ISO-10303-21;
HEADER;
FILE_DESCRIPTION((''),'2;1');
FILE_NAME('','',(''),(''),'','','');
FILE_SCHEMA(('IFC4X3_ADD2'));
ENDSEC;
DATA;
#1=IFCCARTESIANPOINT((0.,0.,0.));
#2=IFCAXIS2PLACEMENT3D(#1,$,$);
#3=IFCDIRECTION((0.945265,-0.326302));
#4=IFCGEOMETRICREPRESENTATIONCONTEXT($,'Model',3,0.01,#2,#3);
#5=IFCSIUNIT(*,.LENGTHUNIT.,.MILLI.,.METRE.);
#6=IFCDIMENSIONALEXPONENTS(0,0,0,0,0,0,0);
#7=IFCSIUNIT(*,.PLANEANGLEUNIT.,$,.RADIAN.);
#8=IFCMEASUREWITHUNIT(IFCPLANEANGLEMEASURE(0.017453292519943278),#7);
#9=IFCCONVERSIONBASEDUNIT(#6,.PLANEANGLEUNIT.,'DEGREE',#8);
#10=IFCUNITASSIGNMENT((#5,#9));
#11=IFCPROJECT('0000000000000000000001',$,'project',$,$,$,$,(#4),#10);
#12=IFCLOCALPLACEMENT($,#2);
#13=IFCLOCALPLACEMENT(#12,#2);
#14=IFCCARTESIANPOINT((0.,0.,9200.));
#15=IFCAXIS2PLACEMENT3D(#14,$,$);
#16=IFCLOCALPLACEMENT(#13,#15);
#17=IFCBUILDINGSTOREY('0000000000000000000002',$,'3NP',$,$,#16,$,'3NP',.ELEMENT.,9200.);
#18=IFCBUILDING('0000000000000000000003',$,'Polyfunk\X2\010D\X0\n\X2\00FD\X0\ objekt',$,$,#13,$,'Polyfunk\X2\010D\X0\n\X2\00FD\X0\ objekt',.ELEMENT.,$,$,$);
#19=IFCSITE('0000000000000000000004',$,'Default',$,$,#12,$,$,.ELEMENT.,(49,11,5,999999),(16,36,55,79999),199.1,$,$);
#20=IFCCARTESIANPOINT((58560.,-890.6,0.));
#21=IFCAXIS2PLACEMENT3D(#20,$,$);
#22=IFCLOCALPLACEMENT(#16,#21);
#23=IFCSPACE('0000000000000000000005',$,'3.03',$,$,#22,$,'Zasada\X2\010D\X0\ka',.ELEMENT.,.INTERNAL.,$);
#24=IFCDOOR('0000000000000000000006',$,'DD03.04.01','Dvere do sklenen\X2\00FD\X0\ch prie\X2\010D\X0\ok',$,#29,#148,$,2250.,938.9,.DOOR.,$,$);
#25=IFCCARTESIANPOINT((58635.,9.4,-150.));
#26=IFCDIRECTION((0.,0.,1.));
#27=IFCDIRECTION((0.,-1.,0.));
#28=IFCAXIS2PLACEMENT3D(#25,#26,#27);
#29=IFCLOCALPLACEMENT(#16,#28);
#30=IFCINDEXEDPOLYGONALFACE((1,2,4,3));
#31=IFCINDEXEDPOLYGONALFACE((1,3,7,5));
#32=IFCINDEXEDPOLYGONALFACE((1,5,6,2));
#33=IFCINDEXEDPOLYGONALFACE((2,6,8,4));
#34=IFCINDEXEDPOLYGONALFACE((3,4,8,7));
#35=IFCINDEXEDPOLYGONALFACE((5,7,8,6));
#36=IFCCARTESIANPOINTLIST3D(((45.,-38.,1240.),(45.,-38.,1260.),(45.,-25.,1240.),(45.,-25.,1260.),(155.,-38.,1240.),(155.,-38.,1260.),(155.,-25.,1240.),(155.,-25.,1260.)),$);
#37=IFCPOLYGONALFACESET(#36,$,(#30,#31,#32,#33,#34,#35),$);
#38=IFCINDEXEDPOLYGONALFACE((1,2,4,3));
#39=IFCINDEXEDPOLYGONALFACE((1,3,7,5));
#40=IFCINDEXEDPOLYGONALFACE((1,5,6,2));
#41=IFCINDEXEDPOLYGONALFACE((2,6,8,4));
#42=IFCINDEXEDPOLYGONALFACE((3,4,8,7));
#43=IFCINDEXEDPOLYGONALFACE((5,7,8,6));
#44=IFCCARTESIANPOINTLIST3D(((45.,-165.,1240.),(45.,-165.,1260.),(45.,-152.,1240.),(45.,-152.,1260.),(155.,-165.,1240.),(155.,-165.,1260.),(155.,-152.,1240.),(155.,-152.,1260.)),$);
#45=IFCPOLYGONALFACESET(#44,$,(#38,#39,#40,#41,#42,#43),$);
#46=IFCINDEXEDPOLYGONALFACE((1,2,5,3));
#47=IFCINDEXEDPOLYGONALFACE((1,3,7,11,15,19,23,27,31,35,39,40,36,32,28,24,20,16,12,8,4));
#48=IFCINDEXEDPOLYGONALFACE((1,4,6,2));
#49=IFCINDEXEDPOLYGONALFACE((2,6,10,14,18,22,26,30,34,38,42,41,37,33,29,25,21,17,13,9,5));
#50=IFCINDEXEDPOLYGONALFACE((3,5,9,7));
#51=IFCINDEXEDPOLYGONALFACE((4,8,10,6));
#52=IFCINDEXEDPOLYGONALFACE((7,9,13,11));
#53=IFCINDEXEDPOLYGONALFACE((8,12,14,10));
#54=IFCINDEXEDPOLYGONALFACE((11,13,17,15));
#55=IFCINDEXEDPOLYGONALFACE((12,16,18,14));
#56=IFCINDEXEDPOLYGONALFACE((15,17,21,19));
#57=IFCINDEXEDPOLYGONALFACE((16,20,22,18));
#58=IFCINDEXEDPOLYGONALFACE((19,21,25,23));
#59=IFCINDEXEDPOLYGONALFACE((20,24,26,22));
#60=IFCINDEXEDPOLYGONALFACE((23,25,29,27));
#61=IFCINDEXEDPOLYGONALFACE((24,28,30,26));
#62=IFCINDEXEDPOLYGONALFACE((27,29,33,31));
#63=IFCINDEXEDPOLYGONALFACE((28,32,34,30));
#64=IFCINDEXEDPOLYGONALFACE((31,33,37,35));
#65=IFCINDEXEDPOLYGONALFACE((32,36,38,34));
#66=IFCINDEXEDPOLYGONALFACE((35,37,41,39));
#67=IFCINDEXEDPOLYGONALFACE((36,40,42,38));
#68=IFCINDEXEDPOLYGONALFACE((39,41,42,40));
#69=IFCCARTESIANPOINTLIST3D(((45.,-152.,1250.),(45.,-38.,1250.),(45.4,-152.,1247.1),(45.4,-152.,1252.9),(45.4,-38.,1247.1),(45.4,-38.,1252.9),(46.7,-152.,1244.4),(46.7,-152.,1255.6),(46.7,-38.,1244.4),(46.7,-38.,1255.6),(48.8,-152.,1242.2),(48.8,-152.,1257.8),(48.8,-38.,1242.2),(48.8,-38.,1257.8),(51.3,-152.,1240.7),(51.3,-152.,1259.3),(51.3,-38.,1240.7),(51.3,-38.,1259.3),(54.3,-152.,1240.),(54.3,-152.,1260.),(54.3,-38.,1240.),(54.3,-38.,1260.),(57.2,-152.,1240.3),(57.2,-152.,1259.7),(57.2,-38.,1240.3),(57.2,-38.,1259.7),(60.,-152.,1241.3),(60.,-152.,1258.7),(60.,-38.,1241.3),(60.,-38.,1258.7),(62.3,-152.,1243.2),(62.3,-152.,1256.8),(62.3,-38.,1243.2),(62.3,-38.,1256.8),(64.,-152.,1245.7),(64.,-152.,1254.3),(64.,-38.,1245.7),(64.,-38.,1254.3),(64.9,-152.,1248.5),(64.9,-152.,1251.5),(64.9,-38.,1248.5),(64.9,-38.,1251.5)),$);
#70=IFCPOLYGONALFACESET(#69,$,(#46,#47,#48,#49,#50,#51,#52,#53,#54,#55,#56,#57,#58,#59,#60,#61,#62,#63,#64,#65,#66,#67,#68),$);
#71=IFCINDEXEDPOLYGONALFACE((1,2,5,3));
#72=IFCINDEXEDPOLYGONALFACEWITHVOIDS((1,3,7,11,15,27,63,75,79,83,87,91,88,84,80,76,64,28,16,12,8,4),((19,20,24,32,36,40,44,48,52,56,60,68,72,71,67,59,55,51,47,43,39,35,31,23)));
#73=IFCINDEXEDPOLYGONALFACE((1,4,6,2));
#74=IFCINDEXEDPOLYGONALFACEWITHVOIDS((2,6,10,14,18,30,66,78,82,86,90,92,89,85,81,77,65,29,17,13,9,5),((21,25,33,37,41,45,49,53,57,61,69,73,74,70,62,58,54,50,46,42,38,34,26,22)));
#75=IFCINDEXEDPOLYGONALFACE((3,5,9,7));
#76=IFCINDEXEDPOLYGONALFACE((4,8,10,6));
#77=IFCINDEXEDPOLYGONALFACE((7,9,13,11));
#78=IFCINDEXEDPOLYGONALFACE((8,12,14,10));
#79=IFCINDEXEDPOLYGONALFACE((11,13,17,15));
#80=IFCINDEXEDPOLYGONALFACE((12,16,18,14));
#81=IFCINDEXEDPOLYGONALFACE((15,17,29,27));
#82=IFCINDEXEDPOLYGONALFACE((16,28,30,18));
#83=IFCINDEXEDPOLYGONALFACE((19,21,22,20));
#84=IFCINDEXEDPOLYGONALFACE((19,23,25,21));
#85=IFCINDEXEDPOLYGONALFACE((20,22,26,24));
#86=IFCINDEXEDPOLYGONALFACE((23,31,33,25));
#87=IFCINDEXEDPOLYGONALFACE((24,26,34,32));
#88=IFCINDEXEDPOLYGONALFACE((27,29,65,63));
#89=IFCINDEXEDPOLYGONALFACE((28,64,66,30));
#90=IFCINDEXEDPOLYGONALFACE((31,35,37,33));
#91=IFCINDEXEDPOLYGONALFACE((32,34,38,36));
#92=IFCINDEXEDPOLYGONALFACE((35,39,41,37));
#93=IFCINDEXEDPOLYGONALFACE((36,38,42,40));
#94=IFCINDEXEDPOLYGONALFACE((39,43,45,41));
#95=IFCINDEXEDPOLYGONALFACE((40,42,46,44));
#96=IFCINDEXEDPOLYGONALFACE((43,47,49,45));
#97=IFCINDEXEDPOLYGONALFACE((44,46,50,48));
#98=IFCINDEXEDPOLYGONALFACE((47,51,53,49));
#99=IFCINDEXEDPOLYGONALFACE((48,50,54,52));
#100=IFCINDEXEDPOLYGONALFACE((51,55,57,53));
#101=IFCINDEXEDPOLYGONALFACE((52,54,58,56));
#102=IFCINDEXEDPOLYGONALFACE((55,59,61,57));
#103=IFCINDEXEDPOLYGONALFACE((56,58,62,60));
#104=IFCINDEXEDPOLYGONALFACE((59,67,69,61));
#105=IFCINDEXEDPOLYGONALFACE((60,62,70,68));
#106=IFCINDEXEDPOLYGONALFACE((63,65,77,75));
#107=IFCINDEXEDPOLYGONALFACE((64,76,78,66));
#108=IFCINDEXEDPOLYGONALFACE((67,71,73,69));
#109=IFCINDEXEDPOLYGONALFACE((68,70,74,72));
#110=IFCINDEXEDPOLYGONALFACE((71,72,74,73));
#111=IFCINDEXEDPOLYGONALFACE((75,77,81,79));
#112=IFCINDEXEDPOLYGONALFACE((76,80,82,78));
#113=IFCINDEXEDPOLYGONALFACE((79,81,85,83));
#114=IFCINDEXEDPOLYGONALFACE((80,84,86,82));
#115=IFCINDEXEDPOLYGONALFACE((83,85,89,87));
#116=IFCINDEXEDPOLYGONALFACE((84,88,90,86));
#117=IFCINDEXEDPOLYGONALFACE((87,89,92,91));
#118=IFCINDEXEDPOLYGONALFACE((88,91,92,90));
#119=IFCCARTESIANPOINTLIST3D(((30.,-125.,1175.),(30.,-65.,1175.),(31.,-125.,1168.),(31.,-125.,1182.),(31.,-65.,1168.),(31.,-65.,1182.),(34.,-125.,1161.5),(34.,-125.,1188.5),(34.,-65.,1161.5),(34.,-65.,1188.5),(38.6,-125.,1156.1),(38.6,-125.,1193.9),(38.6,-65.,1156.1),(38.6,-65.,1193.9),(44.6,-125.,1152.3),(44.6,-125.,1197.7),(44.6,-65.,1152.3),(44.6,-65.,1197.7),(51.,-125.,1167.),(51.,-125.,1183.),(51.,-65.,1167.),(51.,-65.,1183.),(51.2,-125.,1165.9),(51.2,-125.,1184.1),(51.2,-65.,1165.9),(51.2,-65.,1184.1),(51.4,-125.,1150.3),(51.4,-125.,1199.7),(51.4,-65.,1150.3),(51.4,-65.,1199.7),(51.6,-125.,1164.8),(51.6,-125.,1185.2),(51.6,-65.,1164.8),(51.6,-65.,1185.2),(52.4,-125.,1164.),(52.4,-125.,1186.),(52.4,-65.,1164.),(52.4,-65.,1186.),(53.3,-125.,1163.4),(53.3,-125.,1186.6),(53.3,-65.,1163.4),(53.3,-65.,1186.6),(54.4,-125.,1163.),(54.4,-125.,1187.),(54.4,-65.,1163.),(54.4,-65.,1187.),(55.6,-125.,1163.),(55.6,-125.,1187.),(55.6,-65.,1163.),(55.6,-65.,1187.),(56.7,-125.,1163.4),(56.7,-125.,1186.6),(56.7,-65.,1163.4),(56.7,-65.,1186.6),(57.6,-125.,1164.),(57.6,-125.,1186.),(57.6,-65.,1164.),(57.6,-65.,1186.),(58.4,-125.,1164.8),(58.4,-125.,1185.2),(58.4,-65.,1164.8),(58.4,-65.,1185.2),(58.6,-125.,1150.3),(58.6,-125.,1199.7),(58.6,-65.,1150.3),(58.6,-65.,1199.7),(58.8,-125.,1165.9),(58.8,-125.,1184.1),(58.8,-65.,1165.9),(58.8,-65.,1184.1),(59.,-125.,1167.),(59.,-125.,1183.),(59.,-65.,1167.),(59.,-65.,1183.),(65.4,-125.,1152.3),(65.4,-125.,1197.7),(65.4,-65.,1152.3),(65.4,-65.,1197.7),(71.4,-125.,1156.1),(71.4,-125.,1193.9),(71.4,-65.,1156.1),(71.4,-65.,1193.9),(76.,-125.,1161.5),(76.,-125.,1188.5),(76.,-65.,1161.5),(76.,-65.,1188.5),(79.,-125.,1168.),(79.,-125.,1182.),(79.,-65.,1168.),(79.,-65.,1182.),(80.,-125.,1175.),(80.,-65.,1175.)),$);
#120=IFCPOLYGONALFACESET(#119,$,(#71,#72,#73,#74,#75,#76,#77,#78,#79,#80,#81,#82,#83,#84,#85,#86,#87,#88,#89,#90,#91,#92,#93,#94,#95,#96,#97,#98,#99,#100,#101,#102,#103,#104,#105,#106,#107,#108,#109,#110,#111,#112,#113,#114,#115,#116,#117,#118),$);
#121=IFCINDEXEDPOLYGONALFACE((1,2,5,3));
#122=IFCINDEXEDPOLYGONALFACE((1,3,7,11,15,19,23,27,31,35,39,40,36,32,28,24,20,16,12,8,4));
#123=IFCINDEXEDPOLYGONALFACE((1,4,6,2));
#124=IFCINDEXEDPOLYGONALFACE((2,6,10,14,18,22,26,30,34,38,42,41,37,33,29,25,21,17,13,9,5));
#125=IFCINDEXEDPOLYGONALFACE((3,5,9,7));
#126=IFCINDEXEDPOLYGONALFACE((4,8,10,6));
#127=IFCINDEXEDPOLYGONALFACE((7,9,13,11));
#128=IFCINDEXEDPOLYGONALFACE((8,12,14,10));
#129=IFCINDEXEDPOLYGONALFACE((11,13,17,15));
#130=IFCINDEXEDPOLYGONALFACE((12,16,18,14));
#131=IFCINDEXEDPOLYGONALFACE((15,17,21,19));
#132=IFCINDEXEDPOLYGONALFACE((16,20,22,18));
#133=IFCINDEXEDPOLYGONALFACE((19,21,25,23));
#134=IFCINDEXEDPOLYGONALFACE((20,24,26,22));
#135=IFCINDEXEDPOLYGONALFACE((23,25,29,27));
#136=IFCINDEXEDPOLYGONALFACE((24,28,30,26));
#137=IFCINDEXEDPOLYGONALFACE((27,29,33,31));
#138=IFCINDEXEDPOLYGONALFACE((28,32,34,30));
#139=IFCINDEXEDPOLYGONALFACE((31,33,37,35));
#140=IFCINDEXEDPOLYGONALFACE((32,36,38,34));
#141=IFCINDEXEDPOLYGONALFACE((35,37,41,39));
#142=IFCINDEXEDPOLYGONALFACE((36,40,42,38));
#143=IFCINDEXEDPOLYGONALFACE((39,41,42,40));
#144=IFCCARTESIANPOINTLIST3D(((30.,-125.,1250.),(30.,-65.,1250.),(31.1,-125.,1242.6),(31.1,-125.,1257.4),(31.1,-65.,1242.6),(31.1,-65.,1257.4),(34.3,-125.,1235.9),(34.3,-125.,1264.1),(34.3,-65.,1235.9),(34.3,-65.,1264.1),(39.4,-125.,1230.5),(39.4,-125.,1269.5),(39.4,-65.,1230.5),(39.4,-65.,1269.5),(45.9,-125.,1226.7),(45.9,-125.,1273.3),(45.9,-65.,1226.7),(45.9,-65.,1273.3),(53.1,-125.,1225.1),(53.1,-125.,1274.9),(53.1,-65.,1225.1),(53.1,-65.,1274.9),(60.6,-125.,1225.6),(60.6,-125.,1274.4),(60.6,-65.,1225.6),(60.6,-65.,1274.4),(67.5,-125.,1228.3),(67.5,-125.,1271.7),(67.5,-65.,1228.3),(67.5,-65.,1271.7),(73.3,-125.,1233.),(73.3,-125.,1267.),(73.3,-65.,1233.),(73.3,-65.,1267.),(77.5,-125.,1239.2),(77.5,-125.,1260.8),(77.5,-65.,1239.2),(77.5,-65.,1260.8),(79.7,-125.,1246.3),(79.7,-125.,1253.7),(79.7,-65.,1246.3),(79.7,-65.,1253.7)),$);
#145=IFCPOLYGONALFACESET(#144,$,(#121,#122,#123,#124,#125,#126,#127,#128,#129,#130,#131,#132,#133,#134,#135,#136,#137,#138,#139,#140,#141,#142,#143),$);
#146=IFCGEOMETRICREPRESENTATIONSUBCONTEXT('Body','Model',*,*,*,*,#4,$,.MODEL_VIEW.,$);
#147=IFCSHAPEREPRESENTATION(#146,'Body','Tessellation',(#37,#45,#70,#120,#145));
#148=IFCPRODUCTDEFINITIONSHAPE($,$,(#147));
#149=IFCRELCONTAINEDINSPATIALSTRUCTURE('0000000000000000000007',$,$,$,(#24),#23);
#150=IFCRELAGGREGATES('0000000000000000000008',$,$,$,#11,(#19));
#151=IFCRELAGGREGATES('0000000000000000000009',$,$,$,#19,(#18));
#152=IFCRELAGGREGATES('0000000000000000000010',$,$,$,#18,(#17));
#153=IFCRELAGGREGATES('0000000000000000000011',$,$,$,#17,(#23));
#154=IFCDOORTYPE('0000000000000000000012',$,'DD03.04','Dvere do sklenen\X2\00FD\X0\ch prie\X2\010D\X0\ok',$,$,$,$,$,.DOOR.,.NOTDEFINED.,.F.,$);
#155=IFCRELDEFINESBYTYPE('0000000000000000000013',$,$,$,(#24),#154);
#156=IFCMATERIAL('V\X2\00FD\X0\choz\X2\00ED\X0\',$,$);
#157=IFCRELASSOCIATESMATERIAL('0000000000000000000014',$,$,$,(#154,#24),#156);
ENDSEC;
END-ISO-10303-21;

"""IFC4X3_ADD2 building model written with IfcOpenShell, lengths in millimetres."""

from ifc_helpers import new_model, entity, si_unit, converted_unit, direction, frame, frame_2d, origin, origin_2d_with_axis, place, context, subcontext, project, spatial, polyline, circle_curve, parameter, trimmed, segment, composite_curve, rectangle, circle, outline, extrude, source, transform, mapped, material, type_object, type_shapes, element, save


model = new_model("IFC4X3_ADD2")

# Units and contexts
model_context = context("Model", 3, precision=0.01, world=origin(), true_north=direction((0.945265, -0.326302)))
body_context = subcontext(model_context, "Body", "Model", "MODEL_VIEW")
ifc_project = project(units=[si_unit("LENGTHUNIT", "METRE", prefix="MILLI"), converted_unit("PLANEANGLEUNIT", "DEGREE", entity("IfcPlaneAngleMeasure", 0.017453292519943278), si_unit("PLANEANGLEUNIT", "RADIAN"), dimensions=[0, 0, 0, 0, 0, 0, 0])], contexts=[model_context])

# Site, building, storey
site_placement = place(None, origin())
site = spatial("IfcSite", under=ifc_project, at=site_placement, Name="Default", CompositionType="ELEMENT", RefLatitude=(49, 11, 5, 999999), RefLongitude=(16, 36, 55, 79999), RefElevation=199.1)
building_placement = place(site_placement, origin())
building = spatial("IfcBuilding", under=site, at=building_placement, Name="Polyfunkčný objekt", LongName="Polyfunkčný objekt", CompositionType="ELEMENT")
storey_placement = place(building_placement, frame((0.0, 0.0, 9200.0)))
storey = spatial("IfcBuildingStorey", under=building, at=storey_placement, Name="3NP", LongName="3NP", CompositionType="ELEMENT", Elevation=9200.0)

# Shared definitions
space_placement = place(storey_placement, frame((58560.0, -890.6, 0.0)))
space = spatial("IfcSpace", under=storey, at=space_placement, Name="3.03", LongName="Zasadačka", CompositionType="ELEMENT", PredefinedType="INTERNAL")

# Door
ifc_material_1 = material(Name="Výchozí")
door_type = type_object("IfcDoorType", Name="DD03.04", Description="Dvere do sklenených priečok", OperationType="NOTDEFINED", ParameterTakesPrecedence=False, PredefinedType="DOOR", material=ifc_material_1)
shared_shape_1 = source(origin(), body_context, "Body", "SweptSolid", [
    extrude(rectangle(XDim=110.0, YDim=13.0, at=frame_2d((0.0, 0.0), x_axis=(1.0, 0.0))), frame((100.0, -31.5, 1240.0)), (0.0, 0.0, 1.0), 20.0),
    extrude(rectangle(XDim=110.0, YDim=13.0, at=origin_2d_with_axis()), frame((100.0, -158.5, 1240.0), z_axis=(0.0, 0.0, 1.0), x_axis=(-1.0, 0.0, 0.0)), (0.0, 0.0, 1.0), 20.0),
    extrude(circle(Radius=10.0, at=origin_2d_with_axis()), frame((55.0, -152.0, 1250.0), z_axis=(0.0, 1.0, 0.0), x_axis=(-1.0, 0.0, 0.0)), (0.0, 0.0, 1.0), 114.0),
    extrude(outline(composite_curve([segment(trimmed(circle_curve(origin_2d_with_axis(), 25.0), [parameter(180.0)], [parameter(360.0)], True, "PARAMETER"), True, "CONTINUOUS"), segment(trimmed(circle_curve(origin_2d_with_axis(), 25.0), [parameter(0.0)], [parameter(180.0)], True, "PARAMETER"), True, "CONTINUOUS")], self_intersect=False), holes=[composite_curve([segment(trimmed(circle_curve(frame_2d((0.0, 8.0), x_axis=(1.0, 0.0)), 4.0), [parameter(0.0)], [parameter(180.0)], True, "PARAMETER"), False, "CONTINUOUS"), segment(polyline([(4.0, 8.0), (4.0, -8.0)]), True, "CONTINUOUS"), segment(trimmed(circle_curve(frame_2d((0.0, -8.0), x_axis=(1.0, 0.0)), 4.0), [parameter(180.0)], [parameter(0.0)], True, "PARAMETER"), False, "CONTINUOUS"), segment(polyline([(-4.0, -8.0), (-4.0, 8.0)]), True, "CONTINUOUS")], self_intersect=False)]), frame((55.0, -125.0, 1175.0), z_axis=(0.0, 1.0, 0.0), x_axis=(-1.0, 0.0, 0.0)), (0.0, 0.0, 1.0), 60.0),
    extrude(circle(Radius=25.0, at=frame_2d((0.0, 0.0), x_axis=(1.0, 0.0))), frame((55.0, -125.0, 1250.0), z_axis=(0.0, 1.0, 0.0), x_axis=(-1.0, 0.0, 0.0)), (0.0, 0.0, 1.0), 60.0),
])
type_shapes(door_type, [shared_shape_1])
door_placement = place(storey_placement, frame((58635.0, 9.4, -150.0), z_axis=(0.0, 0.0, 1.0), x_axis=(0.0, -1.0, 0.0)))
element("IfcDoor", 1, at=door_placement, inside=space, type_object=door_type, material=ifc_material_1, Name="DD03.04.01", Description="Dvere do sklenených priečok", OverallHeight=2250.0, OverallWidth=938.9, PredefinedType="DOOR", context=body_context, shape_type="MappedRepresentation", body=[
    mapped(shared_shape_1, transform((0.0, 0.0, 0.0), scale=1.0)),
])

save(model, "model.ifc")
